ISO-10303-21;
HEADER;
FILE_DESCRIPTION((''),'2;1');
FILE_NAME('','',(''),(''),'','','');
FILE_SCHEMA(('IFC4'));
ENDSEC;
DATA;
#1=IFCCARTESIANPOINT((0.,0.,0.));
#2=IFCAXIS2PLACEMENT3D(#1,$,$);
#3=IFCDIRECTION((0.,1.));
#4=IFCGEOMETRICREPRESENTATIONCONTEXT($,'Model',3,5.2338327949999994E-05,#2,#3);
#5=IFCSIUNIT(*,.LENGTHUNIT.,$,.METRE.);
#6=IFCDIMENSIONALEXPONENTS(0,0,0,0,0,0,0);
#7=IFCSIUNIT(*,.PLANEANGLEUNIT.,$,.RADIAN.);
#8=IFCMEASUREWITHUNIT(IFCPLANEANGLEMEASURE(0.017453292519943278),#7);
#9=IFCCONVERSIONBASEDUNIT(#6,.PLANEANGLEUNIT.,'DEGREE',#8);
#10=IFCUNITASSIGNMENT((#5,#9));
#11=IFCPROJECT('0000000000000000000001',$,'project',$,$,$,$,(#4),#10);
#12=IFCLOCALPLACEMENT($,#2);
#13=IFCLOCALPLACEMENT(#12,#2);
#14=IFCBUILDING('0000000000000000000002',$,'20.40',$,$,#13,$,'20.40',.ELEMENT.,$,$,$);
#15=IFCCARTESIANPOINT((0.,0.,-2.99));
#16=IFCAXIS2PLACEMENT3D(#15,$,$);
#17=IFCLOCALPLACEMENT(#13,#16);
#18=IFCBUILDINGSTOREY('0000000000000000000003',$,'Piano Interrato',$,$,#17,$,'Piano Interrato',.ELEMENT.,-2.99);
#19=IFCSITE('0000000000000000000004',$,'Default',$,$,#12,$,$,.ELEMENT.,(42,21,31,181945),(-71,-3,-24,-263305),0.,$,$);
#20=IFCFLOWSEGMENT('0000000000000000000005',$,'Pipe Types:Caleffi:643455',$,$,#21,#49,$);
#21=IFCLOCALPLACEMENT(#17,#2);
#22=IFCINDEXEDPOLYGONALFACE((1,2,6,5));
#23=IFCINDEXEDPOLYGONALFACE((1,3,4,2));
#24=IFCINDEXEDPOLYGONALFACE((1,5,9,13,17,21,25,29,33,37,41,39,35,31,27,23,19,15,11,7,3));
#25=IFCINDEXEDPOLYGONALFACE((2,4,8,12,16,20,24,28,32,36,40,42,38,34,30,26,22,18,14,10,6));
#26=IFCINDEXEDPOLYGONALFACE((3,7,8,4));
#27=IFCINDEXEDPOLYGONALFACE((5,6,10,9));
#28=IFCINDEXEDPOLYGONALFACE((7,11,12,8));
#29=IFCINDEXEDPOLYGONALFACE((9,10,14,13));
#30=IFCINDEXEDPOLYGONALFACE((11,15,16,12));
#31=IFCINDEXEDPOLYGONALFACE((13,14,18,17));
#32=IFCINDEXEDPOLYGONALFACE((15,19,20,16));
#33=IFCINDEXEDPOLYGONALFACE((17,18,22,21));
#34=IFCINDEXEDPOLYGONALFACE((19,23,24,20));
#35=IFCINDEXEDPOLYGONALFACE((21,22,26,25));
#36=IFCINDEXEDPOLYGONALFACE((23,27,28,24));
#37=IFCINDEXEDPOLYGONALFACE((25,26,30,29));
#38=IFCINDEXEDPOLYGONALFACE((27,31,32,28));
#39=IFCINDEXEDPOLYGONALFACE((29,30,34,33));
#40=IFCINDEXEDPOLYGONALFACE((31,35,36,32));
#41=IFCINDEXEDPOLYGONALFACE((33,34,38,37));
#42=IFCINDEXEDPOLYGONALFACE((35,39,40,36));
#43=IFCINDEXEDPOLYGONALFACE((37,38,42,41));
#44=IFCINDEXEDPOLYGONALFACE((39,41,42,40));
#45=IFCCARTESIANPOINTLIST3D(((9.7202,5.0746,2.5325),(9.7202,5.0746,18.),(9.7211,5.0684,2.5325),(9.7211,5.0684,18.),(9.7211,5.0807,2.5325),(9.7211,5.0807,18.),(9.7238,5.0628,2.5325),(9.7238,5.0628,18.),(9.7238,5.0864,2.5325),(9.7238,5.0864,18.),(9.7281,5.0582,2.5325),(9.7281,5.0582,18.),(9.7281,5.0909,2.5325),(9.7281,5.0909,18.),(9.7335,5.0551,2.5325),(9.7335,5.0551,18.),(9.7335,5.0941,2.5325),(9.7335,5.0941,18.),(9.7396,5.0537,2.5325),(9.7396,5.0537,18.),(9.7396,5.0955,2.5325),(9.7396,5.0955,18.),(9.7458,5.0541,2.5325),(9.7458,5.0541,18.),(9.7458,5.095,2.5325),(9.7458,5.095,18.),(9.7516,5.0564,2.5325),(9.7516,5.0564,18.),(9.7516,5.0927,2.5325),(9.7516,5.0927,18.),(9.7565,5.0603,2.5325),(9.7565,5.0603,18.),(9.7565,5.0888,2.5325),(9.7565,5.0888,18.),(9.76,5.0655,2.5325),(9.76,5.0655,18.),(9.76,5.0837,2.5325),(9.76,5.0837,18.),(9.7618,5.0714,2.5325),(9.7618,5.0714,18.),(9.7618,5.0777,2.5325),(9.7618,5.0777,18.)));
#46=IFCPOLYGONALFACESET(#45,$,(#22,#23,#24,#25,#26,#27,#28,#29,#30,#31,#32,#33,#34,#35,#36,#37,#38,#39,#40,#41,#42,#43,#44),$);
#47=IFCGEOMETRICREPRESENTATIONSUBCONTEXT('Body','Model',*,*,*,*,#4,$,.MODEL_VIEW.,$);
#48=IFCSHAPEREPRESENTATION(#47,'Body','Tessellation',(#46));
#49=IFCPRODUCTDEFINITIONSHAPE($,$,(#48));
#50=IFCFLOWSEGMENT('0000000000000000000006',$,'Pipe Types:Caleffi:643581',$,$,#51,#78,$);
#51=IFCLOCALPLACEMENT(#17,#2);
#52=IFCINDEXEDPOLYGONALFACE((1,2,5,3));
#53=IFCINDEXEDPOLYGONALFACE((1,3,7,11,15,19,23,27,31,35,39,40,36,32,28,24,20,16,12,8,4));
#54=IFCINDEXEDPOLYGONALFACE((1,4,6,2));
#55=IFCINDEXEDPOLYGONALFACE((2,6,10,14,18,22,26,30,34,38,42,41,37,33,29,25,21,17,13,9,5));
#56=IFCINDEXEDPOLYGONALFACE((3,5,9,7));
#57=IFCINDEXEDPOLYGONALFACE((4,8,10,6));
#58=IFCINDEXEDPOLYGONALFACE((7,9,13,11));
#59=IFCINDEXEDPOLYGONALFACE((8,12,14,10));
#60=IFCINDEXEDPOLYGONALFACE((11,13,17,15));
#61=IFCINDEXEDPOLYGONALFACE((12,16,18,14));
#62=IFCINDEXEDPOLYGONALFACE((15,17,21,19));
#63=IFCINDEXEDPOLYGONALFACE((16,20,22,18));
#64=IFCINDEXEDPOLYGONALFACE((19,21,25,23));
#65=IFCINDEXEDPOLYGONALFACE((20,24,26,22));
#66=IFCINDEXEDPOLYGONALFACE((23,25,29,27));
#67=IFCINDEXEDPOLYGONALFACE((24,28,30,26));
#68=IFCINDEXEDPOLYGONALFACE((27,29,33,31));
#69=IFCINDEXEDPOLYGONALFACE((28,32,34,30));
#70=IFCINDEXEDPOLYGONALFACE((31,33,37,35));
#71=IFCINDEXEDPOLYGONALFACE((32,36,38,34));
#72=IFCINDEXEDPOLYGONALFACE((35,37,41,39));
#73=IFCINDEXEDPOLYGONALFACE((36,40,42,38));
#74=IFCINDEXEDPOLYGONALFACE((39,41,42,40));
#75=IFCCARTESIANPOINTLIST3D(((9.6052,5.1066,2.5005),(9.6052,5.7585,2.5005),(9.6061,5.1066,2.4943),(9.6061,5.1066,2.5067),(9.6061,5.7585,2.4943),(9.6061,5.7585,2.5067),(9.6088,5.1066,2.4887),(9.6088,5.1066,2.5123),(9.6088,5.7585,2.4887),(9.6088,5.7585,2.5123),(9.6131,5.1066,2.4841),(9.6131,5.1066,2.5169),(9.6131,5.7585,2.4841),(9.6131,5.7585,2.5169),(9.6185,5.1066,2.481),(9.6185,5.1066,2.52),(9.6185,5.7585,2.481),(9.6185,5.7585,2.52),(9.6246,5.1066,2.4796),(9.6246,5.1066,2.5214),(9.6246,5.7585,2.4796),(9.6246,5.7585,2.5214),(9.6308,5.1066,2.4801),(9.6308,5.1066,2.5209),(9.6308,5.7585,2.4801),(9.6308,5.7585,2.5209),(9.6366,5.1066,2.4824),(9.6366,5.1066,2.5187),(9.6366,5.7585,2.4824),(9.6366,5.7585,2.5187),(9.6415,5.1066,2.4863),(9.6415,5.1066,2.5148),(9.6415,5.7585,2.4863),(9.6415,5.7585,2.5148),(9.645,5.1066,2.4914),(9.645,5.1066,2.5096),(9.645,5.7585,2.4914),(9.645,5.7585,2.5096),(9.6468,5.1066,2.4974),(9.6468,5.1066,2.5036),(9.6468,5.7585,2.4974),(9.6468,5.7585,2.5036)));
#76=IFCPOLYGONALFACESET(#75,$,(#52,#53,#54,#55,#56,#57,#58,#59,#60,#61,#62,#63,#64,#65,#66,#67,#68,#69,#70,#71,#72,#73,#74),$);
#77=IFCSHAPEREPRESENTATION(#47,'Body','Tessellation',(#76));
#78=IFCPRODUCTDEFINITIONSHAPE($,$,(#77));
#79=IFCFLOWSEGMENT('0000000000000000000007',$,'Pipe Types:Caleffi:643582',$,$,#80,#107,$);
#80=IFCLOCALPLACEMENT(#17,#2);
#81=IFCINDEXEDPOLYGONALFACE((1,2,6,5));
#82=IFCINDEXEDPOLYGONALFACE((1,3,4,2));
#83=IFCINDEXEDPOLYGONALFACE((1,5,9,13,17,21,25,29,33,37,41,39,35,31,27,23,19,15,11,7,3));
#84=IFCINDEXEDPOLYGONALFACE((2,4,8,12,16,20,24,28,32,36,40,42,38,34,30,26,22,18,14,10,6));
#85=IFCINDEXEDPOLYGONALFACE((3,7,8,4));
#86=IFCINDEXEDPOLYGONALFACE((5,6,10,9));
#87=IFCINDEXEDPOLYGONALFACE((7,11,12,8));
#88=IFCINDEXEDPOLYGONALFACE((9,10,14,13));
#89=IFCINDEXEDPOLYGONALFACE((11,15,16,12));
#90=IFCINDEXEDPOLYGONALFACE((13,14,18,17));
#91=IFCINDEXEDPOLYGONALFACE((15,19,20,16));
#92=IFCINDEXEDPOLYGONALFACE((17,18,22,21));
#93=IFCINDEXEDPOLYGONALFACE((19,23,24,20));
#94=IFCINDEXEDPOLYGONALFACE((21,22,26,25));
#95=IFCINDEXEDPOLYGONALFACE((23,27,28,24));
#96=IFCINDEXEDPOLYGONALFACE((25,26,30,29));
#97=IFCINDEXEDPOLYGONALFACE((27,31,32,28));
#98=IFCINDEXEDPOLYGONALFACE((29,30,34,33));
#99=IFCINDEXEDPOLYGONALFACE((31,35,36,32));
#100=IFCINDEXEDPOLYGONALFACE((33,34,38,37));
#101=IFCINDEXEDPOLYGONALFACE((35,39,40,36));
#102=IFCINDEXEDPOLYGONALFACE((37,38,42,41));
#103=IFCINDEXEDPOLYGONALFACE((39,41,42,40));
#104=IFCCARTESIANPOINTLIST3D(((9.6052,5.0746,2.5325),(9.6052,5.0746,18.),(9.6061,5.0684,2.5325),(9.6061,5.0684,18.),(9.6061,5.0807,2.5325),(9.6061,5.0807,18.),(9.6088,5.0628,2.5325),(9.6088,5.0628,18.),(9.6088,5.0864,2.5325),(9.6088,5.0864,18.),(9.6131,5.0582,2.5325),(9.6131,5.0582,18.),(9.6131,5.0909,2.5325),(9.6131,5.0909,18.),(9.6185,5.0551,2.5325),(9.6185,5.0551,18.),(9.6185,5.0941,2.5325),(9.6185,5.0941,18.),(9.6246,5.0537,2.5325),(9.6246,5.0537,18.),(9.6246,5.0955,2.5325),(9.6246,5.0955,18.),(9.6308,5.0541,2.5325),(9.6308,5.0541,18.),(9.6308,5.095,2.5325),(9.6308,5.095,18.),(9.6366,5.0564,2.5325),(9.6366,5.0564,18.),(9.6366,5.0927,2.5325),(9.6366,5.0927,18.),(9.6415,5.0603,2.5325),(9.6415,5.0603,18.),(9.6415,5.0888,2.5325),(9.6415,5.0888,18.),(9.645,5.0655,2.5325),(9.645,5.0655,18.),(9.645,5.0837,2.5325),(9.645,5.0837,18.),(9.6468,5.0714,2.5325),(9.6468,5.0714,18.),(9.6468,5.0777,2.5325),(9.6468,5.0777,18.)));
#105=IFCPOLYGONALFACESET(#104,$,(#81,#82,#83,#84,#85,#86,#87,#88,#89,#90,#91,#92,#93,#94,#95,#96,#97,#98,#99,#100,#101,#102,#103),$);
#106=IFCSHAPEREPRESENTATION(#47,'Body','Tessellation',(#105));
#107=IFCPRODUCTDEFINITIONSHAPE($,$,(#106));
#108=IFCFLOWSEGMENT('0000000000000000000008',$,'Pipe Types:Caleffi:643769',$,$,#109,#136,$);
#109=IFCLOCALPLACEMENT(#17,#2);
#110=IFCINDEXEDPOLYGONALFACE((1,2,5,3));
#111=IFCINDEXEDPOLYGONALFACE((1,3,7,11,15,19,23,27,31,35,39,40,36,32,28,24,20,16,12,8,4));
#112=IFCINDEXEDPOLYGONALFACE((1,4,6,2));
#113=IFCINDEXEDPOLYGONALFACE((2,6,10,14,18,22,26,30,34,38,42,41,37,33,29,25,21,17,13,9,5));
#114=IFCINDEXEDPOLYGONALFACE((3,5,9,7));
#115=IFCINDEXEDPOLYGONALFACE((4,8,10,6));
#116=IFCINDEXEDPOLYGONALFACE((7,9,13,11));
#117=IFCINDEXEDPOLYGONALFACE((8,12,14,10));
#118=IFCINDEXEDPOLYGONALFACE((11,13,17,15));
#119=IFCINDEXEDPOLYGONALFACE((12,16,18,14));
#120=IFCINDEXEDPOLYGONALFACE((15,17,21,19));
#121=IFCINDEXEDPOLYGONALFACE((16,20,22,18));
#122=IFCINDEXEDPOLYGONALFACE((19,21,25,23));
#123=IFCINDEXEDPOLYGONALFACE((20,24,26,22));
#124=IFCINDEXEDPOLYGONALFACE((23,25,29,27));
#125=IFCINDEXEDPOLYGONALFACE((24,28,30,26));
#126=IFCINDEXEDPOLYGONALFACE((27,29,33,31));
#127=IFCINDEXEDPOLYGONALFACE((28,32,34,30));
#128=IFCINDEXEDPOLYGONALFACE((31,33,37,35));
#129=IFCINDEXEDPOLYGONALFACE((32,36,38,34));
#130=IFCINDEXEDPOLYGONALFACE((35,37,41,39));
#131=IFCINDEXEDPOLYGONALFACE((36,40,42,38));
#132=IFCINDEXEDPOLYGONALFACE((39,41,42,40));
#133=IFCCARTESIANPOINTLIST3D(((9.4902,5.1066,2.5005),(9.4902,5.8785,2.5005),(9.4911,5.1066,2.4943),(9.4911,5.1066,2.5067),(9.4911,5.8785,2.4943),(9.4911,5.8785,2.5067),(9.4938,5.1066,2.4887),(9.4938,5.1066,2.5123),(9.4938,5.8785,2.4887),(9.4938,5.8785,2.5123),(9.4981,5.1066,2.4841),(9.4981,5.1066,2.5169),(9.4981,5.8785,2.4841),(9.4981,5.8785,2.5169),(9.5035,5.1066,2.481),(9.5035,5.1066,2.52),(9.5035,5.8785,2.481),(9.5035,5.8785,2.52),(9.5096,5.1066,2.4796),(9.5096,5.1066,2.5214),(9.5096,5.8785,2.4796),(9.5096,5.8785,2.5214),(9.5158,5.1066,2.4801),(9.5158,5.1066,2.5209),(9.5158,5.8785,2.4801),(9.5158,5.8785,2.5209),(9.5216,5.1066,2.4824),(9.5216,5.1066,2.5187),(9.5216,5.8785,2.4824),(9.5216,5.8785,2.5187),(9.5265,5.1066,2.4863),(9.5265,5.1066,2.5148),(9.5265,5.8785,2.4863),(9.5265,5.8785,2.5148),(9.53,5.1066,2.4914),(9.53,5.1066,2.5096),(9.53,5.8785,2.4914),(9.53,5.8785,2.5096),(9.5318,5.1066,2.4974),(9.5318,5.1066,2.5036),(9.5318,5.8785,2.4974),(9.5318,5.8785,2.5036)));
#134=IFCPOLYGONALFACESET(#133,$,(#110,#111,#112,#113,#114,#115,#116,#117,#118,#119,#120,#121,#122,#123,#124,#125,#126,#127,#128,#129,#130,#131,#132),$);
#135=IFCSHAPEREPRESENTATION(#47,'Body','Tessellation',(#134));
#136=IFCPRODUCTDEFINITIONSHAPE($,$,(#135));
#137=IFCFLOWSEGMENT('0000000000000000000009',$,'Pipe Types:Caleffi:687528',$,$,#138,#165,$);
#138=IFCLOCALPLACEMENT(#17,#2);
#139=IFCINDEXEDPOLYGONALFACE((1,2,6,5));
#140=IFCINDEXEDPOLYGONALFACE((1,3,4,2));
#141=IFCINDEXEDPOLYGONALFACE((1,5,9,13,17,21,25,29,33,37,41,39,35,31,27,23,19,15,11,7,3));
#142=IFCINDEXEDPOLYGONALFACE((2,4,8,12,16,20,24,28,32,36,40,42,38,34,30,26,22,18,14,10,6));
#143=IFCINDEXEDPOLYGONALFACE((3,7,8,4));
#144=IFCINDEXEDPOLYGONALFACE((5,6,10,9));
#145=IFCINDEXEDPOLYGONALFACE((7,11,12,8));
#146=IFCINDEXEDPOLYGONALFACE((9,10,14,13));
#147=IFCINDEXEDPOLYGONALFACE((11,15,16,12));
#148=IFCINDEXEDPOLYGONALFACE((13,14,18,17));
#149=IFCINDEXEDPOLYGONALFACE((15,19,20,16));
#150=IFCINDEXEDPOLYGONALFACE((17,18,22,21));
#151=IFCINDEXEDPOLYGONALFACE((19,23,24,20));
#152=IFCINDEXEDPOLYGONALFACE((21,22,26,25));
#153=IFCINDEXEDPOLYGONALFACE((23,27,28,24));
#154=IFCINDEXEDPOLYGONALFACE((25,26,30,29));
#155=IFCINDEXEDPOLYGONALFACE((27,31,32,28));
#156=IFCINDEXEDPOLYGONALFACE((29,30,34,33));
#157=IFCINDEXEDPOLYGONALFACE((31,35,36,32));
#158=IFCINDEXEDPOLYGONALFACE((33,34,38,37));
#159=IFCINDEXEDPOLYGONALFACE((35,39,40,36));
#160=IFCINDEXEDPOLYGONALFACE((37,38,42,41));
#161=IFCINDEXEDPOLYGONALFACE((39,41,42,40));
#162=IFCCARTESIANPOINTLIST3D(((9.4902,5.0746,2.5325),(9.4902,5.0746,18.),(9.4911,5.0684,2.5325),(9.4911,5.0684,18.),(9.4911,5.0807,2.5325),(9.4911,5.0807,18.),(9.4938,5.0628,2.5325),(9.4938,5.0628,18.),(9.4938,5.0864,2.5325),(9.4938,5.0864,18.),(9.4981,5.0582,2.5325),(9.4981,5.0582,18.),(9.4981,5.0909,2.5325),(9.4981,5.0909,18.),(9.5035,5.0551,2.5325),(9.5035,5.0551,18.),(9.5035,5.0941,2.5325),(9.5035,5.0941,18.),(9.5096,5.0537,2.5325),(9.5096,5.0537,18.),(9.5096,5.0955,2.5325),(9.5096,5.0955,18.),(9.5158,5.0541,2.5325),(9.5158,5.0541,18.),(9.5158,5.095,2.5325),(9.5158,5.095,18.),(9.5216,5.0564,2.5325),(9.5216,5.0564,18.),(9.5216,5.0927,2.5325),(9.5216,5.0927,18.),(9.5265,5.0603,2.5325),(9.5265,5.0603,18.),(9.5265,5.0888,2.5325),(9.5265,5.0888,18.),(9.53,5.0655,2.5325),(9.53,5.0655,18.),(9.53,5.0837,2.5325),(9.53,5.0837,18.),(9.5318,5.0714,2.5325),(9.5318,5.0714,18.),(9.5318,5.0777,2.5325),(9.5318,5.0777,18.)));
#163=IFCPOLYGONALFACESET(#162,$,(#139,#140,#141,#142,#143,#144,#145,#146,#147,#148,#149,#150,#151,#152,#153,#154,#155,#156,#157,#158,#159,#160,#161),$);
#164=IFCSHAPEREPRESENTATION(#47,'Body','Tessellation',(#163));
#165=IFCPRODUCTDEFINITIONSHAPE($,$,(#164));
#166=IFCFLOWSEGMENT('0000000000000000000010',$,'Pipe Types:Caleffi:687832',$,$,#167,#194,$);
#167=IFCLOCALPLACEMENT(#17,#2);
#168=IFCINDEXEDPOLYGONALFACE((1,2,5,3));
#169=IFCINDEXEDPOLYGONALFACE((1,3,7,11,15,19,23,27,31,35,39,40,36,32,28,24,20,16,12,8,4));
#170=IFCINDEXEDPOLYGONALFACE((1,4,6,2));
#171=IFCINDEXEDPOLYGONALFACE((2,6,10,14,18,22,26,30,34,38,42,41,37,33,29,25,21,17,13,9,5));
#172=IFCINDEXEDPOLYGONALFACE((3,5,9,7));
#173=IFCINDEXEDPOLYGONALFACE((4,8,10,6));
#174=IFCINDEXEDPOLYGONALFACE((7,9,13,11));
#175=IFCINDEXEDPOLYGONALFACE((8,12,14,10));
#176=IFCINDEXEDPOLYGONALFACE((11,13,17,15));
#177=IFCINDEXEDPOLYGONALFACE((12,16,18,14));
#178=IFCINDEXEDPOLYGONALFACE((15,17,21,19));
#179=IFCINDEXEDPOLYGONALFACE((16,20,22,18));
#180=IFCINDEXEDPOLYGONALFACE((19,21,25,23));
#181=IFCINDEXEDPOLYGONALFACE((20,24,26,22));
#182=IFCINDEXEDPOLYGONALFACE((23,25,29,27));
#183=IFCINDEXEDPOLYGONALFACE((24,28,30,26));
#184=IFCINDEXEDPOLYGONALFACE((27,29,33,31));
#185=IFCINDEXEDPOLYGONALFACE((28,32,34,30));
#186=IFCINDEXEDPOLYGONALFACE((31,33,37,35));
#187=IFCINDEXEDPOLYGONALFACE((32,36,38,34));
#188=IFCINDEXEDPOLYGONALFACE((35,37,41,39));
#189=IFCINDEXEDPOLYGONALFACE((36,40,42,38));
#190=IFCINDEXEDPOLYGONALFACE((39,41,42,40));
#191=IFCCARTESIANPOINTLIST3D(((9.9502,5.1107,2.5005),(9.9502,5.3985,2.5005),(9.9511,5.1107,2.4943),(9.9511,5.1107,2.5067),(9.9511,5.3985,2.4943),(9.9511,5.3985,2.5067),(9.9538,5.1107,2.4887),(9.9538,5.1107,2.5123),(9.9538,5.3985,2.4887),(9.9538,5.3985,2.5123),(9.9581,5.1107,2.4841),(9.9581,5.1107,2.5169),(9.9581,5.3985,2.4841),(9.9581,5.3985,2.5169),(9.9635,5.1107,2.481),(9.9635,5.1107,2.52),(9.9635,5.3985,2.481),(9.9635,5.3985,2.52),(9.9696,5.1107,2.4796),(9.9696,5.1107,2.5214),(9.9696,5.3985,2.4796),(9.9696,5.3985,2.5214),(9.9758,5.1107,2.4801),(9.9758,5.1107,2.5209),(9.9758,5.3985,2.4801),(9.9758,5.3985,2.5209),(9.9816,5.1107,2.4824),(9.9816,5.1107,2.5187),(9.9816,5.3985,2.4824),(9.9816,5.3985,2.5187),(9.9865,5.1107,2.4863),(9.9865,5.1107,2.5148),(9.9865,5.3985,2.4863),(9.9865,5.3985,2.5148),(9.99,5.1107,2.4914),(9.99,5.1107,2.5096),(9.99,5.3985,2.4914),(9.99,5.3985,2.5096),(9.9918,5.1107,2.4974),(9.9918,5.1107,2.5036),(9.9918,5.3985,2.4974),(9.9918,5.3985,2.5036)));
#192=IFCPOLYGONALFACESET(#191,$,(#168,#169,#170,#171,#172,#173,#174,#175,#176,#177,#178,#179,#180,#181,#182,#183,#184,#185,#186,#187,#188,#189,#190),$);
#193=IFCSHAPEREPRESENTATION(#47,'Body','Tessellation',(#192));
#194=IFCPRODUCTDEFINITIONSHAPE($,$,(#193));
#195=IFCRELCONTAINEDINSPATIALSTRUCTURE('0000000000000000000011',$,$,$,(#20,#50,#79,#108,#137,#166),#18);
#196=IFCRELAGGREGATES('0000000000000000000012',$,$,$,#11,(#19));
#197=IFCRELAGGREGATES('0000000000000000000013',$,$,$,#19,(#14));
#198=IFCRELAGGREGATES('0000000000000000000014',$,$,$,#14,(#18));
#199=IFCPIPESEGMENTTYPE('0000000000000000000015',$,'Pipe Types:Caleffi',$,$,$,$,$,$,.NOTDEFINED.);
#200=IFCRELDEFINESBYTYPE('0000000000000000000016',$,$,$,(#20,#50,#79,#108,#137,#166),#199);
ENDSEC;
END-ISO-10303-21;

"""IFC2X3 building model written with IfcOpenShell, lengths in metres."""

from ifc_helpers import new_model, entity, si_unit, converted_unit, direction, frame, frame_2d, origin, origin_2d_with_axis, place, context, subcontext, project, spatial, circle, extrude, type_object, element, save


model = new_model("IFC2X3")

# Units and contexts
model_context = context("Model", 3, precision=5.2338327949999994e-05, world=origin(), true_north=direction((0.0, 1.0)))
body_context = subcontext(model_context, "Body", "Model", "MODEL_VIEW")
ifc_project = project(units=[si_unit("LENGTHUNIT", "METRE"), converted_unit("PLANEANGLEUNIT", "DEGREE", entity("IfcPlaneAngleMeasure", 0.017453292519943278), si_unit("PLANEANGLEUNIT", "RADIAN"), dimensions=[0, 0, 0, 0, 0, 0, 0])], contexts=[model_context])

# Site, building, storey
site_placement = place(None, origin())
site = spatial("IfcSite", under=ifc_project, at=site_placement, Name="Default", CompositionType="ELEMENT", RefLatitude=(42, 21, 31, 181945), RefLongitude=(-71, -3, -24, -263305), RefElevation=0.0)
building_placement = place(site_placement, origin())
building = spatial("IfcBuilding", under=site, at=building_placement, Name="20.40", LongName="20.40", CompositionType="ELEMENT")
storey_placement = place(building_placement, frame((0.0, 0.0, -2.99)))
storey = spatial("IfcBuildingStorey", under=building, at=storey_placement, Name="Piano Interrato", LongName="Piano Interrato", CompositionType="ELEMENT", Elevation=-2.99)

# Flow segments
pipe_segment_type_1 = type_object("IfcPipeSegmentType", Name="Pipe Types:Caleffi", PredefinedType="NOTDEFINED")
flow_segment_1_placement = place(storey_placement, origin())
element("IfcFlowSegment", 1, at=flow_segment_1_placement, inside=storey, type_object=pipe_segment_type_1, Name="Pipe Types:Caleffi:643455", context=body_context, shape_type="SweptSolid", body=[
    extrude(circle(Radius=0.0209, at=origin_2d_with_axis()), frame((9.7411, 5.0746, 2.5325), z_axis=(0.0, 0.0, 1.0), x_axis=(-1.0, 0.0, 0.0)), (0.0, 0.0, 1.0), 15.4675),
])
flow_segment_2_placement = place(storey_placement, origin())
element("IfcFlowSegment", 2, at=flow_segment_2_placement, inside=storey, type_object=pipe_segment_type_1, Name="Pipe Types:Caleffi:643581", context=body_context, shape_type="SweptSolid", body=[
    extrude(circle(Radius=0.0209, at=frame_2d((0.0, 0.0), x_axis=(1.0, 0.0))), frame((9.6261, 5.1066, 2.5005), z_axis=(0.0, 1.0, 0.0), x_axis=(-1.0, 0.0, 0.0)), (0.0, 0.0, 1.0), 0.6519),
])
flow_segment_3_placement = place(storey_placement, origin())
element("IfcFlowSegment", 3, at=flow_segment_3_placement, inside=storey, type_object=pipe_segment_type_1, Name="Pipe Types:Caleffi:643582", context=body_context, shape_type="SweptSolid", body=[
    extrude(circle(Radius=0.0209, at=origin_2d_with_axis()), frame((9.6261, 5.0746, 2.5325), z_axis=(0.0, 0.0, 1.0), x_axis=(-1.0, 0.0, 0.0)), (0.0, 0.0, 1.0), 15.4675),
])
flow_segment_4_placement = place(storey_placement, origin())
element("IfcFlowSegment", 4, at=flow_segment_4_placement, inside=storey, type_object=pipe_segment_type_1, Name="Pipe Types:Caleffi:643769", context=body_context, shape_type="SweptSolid", body=[
    extrude(circle(Radius=0.0209, at=frame_2d((0.0, 0.0), x_axis=(1.0, 0.0))), frame((9.5111, 5.1066, 2.5005), z_axis=(0.0, 1.0, 0.0), x_axis=(-1.0, 0.0, 0.0)), (0.0, 0.0, 1.0), 0.7719),
])
flow_segment_5_placement = place(storey_placement, origin())
element("IfcFlowSegment", 5, at=flow_segment_5_placement, inside=storey, type_object=pipe_segment_type_1, Name="Pipe Types:Caleffi:687528", context=body_context, shape_type="SweptSolid", body=[
    extrude(circle(Radius=0.0209, at=origin_2d_with_axis()), frame((9.5111, 5.0746, 2.5325), z_axis=(0.0, 0.0, 1.0), x_axis=(-1.0, 0.0, 0.0)), (0.0, 0.0, 1.0), 15.4675),
])
flow_segment_6_placement = place(storey_placement, origin())
element("IfcFlowSegment", 6, at=flow_segment_6_placement, inside=storey, type_object=pipe_segment_type_1, Name="Pipe Types:Caleffi:687832", context=body_context, shape_type="SweptSolid", body=[
    extrude(circle(Radius=0.0209, at=frame_2d((0.0, 0.0), x_axis=(1.0, 0.0))), frame((9.9711, 5.1107, 2.5005), z_axis=(0.0, 1.0, 0.0), x_axis=(-1.0, 0.0, 0.0)), (0.0, 0.0, 1.0), 0.2878),
])

save(model, "model.ifc")
